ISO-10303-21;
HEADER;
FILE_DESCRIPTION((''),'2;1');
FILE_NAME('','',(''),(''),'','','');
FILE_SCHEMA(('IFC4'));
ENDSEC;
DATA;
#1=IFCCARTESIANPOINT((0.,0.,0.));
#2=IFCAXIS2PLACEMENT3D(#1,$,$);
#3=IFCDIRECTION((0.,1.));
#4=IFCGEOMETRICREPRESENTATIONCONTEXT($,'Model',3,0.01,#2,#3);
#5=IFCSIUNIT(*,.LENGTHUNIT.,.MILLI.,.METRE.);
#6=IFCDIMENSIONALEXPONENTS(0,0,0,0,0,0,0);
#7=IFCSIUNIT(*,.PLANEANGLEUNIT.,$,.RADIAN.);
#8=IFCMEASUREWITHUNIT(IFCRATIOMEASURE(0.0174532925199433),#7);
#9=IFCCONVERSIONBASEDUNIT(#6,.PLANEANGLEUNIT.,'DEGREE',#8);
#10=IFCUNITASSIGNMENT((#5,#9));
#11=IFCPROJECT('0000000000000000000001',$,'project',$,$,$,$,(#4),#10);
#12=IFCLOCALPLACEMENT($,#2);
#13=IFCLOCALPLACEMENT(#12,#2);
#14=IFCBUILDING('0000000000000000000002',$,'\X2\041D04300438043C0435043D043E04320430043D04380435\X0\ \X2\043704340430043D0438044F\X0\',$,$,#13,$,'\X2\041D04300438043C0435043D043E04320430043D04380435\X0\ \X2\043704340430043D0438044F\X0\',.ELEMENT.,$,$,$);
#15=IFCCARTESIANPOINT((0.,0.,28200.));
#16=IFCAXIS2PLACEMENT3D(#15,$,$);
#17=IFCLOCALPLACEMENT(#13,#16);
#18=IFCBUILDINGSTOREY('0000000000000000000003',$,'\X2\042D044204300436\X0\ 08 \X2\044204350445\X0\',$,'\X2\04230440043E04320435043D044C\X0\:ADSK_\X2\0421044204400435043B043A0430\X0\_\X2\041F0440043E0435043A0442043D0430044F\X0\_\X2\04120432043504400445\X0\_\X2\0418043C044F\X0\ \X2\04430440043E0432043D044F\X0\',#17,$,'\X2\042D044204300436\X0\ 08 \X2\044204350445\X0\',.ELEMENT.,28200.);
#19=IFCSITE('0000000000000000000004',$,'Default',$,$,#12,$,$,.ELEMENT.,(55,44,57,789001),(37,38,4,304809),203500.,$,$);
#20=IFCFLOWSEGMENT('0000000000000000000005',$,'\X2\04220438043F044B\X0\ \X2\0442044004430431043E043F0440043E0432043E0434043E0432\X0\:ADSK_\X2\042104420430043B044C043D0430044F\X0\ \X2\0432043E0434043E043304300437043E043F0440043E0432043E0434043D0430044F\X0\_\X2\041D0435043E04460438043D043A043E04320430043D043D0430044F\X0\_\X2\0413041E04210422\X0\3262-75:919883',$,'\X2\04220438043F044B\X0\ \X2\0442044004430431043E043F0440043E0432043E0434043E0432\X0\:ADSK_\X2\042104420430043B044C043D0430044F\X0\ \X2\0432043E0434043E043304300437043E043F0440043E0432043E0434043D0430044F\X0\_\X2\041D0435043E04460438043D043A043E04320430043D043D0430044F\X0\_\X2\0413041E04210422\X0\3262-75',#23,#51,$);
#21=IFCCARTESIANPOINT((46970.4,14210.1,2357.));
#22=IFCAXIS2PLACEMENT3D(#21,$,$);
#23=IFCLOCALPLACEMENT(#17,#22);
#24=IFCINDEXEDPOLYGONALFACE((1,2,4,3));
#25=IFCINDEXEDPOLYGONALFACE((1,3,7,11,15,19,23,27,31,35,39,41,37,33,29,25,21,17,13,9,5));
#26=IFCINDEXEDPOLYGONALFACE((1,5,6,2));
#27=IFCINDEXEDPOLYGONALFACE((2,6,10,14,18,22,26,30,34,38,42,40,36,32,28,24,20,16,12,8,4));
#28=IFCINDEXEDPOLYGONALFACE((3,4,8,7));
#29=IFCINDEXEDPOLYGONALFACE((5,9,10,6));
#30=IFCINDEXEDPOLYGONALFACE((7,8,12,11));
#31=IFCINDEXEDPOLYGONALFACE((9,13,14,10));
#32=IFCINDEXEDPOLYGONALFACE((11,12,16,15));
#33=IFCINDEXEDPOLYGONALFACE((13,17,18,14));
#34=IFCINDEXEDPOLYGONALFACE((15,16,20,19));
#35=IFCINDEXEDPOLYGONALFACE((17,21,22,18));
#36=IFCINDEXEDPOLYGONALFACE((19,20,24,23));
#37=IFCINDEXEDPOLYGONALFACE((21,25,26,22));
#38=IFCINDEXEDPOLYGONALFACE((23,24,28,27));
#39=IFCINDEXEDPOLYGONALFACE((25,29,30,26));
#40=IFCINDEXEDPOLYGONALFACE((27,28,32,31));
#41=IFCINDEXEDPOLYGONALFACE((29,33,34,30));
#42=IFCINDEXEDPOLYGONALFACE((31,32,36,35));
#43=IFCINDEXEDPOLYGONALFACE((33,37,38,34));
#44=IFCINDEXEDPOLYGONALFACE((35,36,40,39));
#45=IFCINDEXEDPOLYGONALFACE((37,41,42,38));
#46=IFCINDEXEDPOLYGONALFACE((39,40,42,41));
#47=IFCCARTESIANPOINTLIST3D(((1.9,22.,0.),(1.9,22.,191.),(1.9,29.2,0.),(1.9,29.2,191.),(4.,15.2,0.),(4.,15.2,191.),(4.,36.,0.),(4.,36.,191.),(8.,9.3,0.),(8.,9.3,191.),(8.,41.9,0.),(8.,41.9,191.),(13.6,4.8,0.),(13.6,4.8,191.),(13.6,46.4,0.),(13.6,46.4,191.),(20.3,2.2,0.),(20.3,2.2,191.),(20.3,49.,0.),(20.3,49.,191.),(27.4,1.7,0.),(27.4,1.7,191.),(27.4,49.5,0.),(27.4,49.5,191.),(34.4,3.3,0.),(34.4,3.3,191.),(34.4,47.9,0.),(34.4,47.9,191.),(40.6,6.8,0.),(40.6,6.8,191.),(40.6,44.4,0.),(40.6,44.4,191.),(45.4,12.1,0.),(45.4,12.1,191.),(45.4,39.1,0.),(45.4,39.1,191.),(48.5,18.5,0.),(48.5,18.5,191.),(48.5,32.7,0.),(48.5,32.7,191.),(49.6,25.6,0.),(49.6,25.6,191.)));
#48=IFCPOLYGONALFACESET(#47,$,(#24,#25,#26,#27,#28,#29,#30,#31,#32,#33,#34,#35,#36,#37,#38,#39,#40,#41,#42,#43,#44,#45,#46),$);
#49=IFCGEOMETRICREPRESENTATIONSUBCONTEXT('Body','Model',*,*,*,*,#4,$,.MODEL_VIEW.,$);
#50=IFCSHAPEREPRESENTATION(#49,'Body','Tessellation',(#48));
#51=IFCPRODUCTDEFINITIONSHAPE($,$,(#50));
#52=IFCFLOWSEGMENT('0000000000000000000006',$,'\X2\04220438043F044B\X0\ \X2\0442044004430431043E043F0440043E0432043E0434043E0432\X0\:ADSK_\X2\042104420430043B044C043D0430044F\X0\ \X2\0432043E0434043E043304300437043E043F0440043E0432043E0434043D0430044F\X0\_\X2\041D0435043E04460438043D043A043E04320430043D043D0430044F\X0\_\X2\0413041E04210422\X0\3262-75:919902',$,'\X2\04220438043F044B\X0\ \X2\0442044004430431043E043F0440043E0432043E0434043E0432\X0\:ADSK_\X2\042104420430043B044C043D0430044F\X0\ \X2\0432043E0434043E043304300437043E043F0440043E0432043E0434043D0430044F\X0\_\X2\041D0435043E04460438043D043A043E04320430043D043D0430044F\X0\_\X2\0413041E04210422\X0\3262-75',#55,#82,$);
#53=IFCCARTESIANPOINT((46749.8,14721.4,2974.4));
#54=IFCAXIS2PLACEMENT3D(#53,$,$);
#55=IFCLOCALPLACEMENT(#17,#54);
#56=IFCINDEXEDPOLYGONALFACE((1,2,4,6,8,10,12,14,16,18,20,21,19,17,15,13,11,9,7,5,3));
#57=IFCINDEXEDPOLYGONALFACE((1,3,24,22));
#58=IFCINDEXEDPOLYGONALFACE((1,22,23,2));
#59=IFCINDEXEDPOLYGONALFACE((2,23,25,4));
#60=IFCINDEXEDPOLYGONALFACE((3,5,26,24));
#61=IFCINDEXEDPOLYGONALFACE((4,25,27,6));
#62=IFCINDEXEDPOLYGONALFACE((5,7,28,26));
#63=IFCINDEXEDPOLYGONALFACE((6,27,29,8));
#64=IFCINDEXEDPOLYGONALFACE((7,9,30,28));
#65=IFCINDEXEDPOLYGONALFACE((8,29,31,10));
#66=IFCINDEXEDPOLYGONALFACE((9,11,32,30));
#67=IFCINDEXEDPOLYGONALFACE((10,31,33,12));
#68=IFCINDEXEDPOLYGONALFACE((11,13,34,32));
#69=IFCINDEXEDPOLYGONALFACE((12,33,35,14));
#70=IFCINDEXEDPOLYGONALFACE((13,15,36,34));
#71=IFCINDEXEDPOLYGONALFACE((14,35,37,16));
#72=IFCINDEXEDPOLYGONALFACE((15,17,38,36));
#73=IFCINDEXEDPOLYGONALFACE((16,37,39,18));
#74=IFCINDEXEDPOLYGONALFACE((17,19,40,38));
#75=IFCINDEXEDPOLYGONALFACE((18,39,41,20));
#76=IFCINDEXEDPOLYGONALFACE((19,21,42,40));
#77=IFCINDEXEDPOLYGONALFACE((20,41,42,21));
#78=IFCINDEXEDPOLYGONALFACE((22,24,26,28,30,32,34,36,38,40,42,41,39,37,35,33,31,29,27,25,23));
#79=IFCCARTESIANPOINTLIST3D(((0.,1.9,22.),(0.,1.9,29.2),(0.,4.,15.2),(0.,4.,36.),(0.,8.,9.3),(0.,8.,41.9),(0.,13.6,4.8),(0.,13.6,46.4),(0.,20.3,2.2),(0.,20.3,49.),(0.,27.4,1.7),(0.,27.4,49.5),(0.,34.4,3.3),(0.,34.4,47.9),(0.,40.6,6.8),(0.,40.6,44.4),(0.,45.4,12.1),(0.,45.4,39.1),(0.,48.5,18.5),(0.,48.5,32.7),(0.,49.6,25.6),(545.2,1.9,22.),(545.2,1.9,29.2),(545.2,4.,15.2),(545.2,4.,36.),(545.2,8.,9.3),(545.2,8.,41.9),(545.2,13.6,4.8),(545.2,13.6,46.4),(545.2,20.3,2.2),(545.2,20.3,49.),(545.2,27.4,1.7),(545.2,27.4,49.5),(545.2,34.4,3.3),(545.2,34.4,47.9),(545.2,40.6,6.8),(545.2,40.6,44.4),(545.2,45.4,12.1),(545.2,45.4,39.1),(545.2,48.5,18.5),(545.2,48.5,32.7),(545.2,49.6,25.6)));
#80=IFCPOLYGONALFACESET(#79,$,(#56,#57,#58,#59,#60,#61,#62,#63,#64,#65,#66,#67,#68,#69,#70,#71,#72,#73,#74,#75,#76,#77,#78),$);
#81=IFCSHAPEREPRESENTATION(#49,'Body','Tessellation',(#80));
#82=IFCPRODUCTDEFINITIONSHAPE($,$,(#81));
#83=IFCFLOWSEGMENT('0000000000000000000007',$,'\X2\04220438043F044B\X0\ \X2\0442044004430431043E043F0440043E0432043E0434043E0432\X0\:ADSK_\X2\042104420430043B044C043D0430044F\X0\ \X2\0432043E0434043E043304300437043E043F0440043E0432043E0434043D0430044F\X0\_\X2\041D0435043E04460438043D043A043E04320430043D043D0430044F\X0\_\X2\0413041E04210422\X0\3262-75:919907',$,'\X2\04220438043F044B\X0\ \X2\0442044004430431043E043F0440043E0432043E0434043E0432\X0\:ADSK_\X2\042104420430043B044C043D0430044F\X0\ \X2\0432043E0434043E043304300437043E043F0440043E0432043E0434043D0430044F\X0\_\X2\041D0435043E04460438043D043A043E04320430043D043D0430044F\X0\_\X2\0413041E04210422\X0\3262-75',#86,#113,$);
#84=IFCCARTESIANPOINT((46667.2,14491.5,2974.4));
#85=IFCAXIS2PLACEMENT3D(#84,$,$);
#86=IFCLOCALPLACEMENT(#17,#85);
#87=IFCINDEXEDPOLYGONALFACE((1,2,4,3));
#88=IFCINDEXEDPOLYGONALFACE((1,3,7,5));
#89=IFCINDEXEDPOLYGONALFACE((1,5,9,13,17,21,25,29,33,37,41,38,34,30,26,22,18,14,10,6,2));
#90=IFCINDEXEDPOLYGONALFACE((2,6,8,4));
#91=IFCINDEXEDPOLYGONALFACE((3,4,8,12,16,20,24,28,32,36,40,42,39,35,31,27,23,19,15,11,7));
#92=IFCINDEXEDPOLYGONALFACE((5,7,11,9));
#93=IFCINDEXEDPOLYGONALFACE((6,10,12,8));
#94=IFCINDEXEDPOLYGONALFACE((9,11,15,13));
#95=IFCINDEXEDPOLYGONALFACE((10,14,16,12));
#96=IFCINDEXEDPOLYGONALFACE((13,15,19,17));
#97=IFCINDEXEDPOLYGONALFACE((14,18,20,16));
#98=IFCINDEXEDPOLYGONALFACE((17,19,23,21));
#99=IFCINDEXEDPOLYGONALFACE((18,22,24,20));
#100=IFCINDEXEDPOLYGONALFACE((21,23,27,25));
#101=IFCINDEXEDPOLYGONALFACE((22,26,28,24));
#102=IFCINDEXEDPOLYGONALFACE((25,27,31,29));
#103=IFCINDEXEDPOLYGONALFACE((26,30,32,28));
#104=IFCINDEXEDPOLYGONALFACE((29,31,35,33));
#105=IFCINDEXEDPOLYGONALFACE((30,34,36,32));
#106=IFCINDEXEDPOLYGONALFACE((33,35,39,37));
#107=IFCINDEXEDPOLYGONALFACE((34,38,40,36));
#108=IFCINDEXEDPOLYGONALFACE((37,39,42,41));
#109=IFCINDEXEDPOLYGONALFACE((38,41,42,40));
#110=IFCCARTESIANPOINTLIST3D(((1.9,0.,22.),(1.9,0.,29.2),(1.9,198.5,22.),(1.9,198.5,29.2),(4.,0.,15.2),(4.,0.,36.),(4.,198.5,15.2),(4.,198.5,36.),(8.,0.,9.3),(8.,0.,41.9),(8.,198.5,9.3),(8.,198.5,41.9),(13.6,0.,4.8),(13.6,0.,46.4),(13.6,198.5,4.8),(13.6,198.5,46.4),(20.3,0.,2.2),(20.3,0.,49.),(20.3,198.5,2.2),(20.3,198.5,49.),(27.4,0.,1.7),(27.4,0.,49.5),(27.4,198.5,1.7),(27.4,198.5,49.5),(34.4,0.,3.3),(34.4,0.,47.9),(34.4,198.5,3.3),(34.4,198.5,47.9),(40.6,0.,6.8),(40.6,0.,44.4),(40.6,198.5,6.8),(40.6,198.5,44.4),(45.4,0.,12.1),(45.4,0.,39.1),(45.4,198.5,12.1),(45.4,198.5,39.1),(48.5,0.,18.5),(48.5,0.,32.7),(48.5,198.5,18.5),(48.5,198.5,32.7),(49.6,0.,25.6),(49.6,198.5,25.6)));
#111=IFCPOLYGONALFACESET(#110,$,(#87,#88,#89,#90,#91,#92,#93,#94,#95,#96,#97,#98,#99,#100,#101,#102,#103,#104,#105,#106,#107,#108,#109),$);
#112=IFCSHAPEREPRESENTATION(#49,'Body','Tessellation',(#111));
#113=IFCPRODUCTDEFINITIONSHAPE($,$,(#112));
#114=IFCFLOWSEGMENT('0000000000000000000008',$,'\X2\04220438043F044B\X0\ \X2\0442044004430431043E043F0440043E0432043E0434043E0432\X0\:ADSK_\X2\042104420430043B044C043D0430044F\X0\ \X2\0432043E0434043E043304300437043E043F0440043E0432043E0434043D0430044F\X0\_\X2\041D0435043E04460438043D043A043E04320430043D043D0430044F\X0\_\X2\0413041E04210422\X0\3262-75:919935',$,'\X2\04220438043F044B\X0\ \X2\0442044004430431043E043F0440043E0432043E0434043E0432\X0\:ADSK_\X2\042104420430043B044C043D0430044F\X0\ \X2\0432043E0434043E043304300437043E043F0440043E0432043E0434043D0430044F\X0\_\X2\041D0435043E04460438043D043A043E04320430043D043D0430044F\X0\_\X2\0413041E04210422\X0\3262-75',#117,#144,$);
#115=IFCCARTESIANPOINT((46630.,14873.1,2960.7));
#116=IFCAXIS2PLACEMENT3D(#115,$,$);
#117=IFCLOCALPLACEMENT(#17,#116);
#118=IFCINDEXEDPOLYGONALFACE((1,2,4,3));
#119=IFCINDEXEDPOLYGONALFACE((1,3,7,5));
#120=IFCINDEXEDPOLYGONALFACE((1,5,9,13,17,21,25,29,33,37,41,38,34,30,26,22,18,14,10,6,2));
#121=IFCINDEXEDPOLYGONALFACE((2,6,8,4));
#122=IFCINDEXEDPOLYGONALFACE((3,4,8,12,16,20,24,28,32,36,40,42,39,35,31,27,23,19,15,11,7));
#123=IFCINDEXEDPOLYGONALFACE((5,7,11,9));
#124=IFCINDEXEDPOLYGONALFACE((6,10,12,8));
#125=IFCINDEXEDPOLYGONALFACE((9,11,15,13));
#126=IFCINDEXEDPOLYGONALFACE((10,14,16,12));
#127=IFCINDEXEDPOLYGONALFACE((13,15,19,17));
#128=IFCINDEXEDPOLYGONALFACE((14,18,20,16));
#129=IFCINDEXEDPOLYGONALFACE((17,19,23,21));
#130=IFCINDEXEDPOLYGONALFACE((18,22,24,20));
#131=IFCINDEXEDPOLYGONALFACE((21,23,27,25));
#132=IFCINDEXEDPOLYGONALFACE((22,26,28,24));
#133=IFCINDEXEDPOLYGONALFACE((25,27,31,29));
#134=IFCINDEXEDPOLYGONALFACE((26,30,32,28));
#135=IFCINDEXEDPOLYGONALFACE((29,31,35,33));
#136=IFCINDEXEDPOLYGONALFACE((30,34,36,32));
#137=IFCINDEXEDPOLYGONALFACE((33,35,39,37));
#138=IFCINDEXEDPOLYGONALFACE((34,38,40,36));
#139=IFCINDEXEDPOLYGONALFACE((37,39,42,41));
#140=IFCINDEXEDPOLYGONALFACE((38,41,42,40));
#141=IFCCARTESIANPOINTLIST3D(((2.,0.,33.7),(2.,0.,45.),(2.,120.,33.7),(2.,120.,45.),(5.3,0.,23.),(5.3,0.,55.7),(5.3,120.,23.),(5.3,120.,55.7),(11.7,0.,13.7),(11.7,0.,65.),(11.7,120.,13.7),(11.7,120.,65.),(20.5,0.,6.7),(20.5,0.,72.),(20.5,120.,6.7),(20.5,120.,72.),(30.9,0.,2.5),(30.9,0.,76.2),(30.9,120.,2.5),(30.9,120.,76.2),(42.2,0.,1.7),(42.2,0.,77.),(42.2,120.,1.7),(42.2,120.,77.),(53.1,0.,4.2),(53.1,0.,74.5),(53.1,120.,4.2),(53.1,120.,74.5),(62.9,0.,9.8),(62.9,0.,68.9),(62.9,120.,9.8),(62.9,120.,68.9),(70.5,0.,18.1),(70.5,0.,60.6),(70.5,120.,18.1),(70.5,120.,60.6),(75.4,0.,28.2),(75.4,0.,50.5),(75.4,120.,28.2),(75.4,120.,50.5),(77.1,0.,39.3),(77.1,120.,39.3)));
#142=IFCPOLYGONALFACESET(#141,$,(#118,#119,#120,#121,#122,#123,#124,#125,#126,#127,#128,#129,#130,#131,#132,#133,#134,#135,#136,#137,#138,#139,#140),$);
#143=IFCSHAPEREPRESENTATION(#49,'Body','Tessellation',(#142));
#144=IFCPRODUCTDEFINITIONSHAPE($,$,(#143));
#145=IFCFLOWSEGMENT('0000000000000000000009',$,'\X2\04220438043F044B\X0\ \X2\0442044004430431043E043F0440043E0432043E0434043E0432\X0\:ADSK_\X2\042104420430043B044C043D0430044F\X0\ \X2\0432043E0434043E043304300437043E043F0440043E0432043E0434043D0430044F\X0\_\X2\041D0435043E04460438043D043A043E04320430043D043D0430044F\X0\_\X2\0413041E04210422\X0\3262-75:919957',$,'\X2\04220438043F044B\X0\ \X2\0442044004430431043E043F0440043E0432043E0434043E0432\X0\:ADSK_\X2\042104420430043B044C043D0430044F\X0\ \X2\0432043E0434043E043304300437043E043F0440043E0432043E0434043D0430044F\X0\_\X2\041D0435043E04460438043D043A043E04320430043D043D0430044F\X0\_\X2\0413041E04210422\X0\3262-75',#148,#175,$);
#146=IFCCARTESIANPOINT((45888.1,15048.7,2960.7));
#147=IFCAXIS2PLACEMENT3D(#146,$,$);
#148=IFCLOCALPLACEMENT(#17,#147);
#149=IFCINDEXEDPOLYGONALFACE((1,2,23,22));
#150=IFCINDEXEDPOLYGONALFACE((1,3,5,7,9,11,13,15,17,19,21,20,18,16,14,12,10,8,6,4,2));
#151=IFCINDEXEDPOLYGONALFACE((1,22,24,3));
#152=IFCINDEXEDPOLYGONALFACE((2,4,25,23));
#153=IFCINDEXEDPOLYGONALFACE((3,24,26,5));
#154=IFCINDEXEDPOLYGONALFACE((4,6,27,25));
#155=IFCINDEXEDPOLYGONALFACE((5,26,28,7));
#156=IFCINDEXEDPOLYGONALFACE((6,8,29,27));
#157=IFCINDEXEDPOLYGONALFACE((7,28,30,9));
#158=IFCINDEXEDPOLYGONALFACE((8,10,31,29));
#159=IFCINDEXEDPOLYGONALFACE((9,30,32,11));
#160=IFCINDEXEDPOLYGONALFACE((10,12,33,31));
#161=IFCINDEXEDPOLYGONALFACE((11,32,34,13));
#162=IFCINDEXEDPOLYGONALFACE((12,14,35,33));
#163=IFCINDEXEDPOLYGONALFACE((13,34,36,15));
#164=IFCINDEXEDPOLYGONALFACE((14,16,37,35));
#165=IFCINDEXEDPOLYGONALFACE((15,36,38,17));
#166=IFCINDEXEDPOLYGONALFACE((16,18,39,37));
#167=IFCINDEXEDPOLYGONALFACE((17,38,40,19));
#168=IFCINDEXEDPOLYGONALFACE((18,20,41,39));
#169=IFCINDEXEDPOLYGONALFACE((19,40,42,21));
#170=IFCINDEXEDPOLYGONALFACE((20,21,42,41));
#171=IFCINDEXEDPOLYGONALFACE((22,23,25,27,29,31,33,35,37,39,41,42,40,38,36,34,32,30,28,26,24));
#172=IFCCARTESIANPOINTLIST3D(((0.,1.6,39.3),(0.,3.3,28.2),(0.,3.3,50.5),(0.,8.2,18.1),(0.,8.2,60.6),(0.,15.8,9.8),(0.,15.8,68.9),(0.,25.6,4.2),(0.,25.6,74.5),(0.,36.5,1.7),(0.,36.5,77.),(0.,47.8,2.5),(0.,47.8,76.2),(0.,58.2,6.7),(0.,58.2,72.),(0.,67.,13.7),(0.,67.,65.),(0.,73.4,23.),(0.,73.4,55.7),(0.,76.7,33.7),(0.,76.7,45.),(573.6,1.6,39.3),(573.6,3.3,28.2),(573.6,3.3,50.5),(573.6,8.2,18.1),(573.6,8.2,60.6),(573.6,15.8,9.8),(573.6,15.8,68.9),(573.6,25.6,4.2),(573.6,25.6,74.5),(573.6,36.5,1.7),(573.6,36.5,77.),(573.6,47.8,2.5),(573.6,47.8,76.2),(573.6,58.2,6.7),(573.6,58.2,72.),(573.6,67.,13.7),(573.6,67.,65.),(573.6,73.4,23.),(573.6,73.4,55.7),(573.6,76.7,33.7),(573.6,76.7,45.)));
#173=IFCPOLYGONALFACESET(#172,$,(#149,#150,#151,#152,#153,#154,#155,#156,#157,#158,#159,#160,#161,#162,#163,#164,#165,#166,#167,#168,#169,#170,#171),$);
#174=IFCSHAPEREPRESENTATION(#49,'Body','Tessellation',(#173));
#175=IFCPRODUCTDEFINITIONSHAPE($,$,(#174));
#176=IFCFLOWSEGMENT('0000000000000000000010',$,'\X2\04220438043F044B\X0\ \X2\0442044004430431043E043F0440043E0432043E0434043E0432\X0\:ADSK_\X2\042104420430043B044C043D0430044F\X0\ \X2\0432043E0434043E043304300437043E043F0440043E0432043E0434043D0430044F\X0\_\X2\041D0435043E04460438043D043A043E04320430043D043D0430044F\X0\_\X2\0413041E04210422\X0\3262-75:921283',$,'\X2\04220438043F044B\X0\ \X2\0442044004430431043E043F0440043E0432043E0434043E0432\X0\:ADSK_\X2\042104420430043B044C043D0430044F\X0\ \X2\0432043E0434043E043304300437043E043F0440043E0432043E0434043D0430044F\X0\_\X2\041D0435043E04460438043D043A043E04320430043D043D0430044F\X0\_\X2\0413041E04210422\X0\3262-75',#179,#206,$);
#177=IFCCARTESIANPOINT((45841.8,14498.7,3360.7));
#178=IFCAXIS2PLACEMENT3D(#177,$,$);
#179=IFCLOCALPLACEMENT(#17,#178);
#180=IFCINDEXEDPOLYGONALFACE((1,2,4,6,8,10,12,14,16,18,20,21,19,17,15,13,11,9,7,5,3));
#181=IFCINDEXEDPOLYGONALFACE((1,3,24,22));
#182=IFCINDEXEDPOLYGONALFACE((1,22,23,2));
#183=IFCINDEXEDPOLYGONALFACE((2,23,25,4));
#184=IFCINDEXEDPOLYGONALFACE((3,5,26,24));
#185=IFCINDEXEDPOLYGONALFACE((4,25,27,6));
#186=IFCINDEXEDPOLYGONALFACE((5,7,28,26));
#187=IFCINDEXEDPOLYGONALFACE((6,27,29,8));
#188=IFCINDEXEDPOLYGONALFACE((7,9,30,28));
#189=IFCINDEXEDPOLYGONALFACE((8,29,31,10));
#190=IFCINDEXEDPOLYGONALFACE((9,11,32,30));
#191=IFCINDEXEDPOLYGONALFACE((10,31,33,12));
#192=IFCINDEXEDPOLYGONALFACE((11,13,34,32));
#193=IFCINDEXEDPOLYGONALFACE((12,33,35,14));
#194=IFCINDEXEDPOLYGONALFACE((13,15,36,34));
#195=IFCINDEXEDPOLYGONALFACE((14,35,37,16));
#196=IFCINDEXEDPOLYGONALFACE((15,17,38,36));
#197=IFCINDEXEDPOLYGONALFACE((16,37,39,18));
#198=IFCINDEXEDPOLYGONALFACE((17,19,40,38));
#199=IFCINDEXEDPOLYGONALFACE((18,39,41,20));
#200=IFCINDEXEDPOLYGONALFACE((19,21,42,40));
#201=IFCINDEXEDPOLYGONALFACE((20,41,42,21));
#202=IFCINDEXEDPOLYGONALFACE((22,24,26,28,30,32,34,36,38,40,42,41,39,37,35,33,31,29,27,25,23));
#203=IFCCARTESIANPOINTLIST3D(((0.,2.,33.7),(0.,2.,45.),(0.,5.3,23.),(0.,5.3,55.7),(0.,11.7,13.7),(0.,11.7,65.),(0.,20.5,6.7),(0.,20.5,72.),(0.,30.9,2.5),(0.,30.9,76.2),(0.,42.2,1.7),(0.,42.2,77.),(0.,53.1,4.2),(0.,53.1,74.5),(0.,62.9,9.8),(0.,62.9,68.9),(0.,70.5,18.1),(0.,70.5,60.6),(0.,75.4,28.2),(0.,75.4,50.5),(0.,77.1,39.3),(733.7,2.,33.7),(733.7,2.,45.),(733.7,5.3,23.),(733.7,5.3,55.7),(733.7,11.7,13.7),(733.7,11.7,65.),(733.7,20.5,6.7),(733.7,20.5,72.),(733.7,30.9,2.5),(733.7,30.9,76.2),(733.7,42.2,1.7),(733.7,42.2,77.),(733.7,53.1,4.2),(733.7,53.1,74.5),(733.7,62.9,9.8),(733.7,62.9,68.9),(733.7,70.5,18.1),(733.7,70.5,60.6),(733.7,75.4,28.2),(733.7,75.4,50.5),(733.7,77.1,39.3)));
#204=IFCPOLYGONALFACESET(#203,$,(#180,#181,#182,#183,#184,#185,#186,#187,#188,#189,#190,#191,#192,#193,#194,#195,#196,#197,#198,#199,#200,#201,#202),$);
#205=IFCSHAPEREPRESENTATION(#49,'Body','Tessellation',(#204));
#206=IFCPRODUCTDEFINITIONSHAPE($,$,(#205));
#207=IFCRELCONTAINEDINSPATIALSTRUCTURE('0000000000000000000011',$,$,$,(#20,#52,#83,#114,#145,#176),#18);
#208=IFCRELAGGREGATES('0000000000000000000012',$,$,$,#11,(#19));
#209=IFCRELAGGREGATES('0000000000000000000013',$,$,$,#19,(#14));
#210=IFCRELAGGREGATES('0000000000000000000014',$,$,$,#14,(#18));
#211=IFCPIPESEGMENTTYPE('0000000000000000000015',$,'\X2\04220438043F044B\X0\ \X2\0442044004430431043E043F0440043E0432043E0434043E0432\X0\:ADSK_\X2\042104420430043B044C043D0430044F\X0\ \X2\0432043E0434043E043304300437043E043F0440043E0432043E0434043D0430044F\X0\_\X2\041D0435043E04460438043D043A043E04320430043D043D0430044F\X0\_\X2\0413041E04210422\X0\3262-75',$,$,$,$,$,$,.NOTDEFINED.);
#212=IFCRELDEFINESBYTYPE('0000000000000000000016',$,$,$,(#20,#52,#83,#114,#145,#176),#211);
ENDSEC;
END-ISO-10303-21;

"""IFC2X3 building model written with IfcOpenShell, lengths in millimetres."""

from ifc_helpers import new_model, entity, si_unit, converted_unit, direction, frame, origin, origin_2d_with_axis, place, context, subcontext, project, spatial, circle, extrude, type_object, element, save


model = new_model("IFC2X3")

# Units and contexts
model_context = context("Model", 3, precision=0.01, world=origin(), true_north=direction((0.0, 1.0)))
body_context = subcontext(model_context, "Body", "Model", "MODEL_VIEW")
ifc_project = project(units=[si_unit("LENGTHUNIT", "METRE", prefix="MILLI"), converted_unit("PLANEANGLEUNIT", "DEGREE", entity("IfcRatioMeasure", 0.0174532925199433), si_unit("PLANEANGLEUNIT", "RADIAN"), dimensions=[0, 0, 0, 0, 0, 0, 0])], contexts=[model_context])

# Site, building, storey
site_placement = place(None, origin())
site = spatial("IfcSite", under=ifc_project, at=site_placement, Name="Default", CompositionType="ELEMENT", RefLatitude=(55, 44, 57, 789001), RefLongitude=(37, 38, 4, 304809), RefElevation=203500.0)
building_placement = place(site_placement, origin())
building = spatial("IfcBuilding", under=site, at=building_placement, Name="Наименование здания", LongName="Наименование здания", CompositionType="ELEMENT")
storey_placement = place(building_placement, frame((0.0, 0.0, 28200.0)))
storey = spatial("IfcBuildingStorey", under=building, at=storey_placement, Name="Этаж 08 тех", ObjectType="Уровень:ADSK_Стрелка_Проектная_Вверх_Имя уровня", LongName="Этаж 08 тех", CompositionType="ELEMENT", Elevation=28200.0)

# Flow segments
pipe_segment_type = type_object("IfcPipeSegmentType", Name="Типы трубопроводов:ADSK_Стальная водогазопроводная_Неоцинкованная_ГОСТ3262-75", PredefinedType="NOTDEFINED")
flow_segment_1_placement = place(storey_placement, frame((46970.4, 14210.1, 2357.0)))
element("IfcFlowSegment", 1, at=flow_segment_1_placement, inside=storey, type_object=pipe_segment_type, Name="Типы трубопроводов:ADSK_Стальная водогазопроводная_Неоцинкованная_ГОСТ3262-75:919883", ObjectType="Типы трубопроводов:ADSK_Стальная водогазопроводная_Неоцинкованная_ГОСТ3262-75", context=body_context, shape_type="SweptSolid", body=[
    extrude(circle(Radius=24.0, at=origin_2d_with_axis()), frame((25.6, 25.6, 0.0)), (0.0, 0.0, 1.0), 191.0),
])
flow_segment_2_placement = place(storey_placement, frame((46749.8, 14721.4, 2974.4)))
element("IfcFlowSegment", 2, at=flow_segment_2_placement, inside=storey, type_object=pipe_segment_type, Name="Типы трубопроводов:ADSK_Стальная водогазопроводная_Неоцинкованная_ГОСТ3262-75:919902", ObjectType="Типы трубопроводов:ADSK_Стальная водогазопроводная_Неоцинкованная_ГОСТ3262-75", context=body_context, shape_type="SweptSolid", body=[
    extrude(circle(Radius=24.0, at=origin_2d_with_axis()), frame((0.0, 25.6, 25.6), z_axis=(1.0, 0.0, 0.0), x_axis=(0.0, 1.0, 0.0)), (0.0, 0.0, 1.0), 545.2),
])
flow_segment_3_placement = place(storey_placement, frame((46667.2, 14491.5, 2974.4)))
element("IfcFlowSegment", 3, at=flow_segment_3_placement, inside=storey, type_object=pipe_segment_type, Name="Типы трубопроводов:ADSK_Стальная водогазопроводная_Неоцинкованная_ГОСТ3262-75:919907", ObjectType="Типы трубопроводов:ADSK_Стальная водогазопроводная_Неоцинкованная_ГОСТ3262-75", context=body_context, shape_type="SweptSolid", body=[
    extrude(circle(Radius=24.0, at=origin_2d_with_axis()), frame((25.6, 0.0, 25.6), z_axis=(0.0, 1.0, 0.0), x_axis=(1.0, 0.0, 0.0)), (0.0, 0.0, 1.0), 198.5),
])
flow_segment_4_placement = place(storey_placement, frame((46630.0, 14873.1, 2960.7)))
element("IfcFlowSegment", 4, at=flow_segment_4_placement, inside=storey, type_object=pipe_segment_type, Name="Типы трубопроводов:ADSK_Стальная водогазопроводная_Неоцинкованная_ГОСТ3262-75:919935", ObjectType="Типы трубопроводов:ADSK_Стальная водогазопроводная_Неоцинкованная_ГОСТ3262-75", context=body_context, shape_type="SweptSolid", body=[
    extrude(circle(Radius=37.8, at=origin_2d_with_axis()), frame((39.4, 0.0, 39.4), z_axis=(0.0, 1.0, 0.0), x_axis=(1.0, 0.0, 0.0)), (0.0, 0.0, 1.0), 120.0),
])
flow_segment_5_placement = place(storey_placement, frame((45888.1, 15048.7, 2960.7)))
element("IfcFlowSegment", 5, at=flow_segment_5_placement, inside=storey, type_object=pipe_segment_type, Name="Типы трубопроводов:ADSK_Стальная водогазопроводная_Неоцинкованная_ГОСТ3262-75:919957", ObjectType="Типы трубопроводов:ADSK_Стальная водогазопроводная_Неоцинкованная_ГОСТ3262-75", context=body_context, shape_type="SweptSolid", body=[
    extrude(circle(Radius=37.8, at=origin_2d_with_axis()), frame((0.0, 39.4, 39.4), z_axis=(1.0, 0.0, 0.0), x_axis=(0.0, -1.0, 0.0)), (0.0, 0.0, 1.0), 573.6),
])
flow_segment_6_placement = place(storey_placement, frame((45841.8, 14498.7, 3360.7)))
element("IfcFlowSegment", 6, at=flow_segment_6_placement, inside=storey, type_object=pipe_segment_type, Name="Типы трубопроводов:ADSK_Стальная водогазопроводная_Неоцинкованная_ГОСТ3262-75:921283", ObjectType="Типы трубопроводов:ADSK_Стальная водогазопроводная_Неоцинкованная_ГОСТ3262-75", context=body_context, shape_type="SweptSolid", body=[
    extrude(circle(Radius=37.8, at=origin_2d_with_axis()), frame((0.0, 39.4, 39.4), z_axis=(1.0, 0.0, 0.0), x_axis=(0.0, 1.0, 0.0)), (0.0, 0.0, 1.0), 733.7),
])

save(model, "model.ifc")
